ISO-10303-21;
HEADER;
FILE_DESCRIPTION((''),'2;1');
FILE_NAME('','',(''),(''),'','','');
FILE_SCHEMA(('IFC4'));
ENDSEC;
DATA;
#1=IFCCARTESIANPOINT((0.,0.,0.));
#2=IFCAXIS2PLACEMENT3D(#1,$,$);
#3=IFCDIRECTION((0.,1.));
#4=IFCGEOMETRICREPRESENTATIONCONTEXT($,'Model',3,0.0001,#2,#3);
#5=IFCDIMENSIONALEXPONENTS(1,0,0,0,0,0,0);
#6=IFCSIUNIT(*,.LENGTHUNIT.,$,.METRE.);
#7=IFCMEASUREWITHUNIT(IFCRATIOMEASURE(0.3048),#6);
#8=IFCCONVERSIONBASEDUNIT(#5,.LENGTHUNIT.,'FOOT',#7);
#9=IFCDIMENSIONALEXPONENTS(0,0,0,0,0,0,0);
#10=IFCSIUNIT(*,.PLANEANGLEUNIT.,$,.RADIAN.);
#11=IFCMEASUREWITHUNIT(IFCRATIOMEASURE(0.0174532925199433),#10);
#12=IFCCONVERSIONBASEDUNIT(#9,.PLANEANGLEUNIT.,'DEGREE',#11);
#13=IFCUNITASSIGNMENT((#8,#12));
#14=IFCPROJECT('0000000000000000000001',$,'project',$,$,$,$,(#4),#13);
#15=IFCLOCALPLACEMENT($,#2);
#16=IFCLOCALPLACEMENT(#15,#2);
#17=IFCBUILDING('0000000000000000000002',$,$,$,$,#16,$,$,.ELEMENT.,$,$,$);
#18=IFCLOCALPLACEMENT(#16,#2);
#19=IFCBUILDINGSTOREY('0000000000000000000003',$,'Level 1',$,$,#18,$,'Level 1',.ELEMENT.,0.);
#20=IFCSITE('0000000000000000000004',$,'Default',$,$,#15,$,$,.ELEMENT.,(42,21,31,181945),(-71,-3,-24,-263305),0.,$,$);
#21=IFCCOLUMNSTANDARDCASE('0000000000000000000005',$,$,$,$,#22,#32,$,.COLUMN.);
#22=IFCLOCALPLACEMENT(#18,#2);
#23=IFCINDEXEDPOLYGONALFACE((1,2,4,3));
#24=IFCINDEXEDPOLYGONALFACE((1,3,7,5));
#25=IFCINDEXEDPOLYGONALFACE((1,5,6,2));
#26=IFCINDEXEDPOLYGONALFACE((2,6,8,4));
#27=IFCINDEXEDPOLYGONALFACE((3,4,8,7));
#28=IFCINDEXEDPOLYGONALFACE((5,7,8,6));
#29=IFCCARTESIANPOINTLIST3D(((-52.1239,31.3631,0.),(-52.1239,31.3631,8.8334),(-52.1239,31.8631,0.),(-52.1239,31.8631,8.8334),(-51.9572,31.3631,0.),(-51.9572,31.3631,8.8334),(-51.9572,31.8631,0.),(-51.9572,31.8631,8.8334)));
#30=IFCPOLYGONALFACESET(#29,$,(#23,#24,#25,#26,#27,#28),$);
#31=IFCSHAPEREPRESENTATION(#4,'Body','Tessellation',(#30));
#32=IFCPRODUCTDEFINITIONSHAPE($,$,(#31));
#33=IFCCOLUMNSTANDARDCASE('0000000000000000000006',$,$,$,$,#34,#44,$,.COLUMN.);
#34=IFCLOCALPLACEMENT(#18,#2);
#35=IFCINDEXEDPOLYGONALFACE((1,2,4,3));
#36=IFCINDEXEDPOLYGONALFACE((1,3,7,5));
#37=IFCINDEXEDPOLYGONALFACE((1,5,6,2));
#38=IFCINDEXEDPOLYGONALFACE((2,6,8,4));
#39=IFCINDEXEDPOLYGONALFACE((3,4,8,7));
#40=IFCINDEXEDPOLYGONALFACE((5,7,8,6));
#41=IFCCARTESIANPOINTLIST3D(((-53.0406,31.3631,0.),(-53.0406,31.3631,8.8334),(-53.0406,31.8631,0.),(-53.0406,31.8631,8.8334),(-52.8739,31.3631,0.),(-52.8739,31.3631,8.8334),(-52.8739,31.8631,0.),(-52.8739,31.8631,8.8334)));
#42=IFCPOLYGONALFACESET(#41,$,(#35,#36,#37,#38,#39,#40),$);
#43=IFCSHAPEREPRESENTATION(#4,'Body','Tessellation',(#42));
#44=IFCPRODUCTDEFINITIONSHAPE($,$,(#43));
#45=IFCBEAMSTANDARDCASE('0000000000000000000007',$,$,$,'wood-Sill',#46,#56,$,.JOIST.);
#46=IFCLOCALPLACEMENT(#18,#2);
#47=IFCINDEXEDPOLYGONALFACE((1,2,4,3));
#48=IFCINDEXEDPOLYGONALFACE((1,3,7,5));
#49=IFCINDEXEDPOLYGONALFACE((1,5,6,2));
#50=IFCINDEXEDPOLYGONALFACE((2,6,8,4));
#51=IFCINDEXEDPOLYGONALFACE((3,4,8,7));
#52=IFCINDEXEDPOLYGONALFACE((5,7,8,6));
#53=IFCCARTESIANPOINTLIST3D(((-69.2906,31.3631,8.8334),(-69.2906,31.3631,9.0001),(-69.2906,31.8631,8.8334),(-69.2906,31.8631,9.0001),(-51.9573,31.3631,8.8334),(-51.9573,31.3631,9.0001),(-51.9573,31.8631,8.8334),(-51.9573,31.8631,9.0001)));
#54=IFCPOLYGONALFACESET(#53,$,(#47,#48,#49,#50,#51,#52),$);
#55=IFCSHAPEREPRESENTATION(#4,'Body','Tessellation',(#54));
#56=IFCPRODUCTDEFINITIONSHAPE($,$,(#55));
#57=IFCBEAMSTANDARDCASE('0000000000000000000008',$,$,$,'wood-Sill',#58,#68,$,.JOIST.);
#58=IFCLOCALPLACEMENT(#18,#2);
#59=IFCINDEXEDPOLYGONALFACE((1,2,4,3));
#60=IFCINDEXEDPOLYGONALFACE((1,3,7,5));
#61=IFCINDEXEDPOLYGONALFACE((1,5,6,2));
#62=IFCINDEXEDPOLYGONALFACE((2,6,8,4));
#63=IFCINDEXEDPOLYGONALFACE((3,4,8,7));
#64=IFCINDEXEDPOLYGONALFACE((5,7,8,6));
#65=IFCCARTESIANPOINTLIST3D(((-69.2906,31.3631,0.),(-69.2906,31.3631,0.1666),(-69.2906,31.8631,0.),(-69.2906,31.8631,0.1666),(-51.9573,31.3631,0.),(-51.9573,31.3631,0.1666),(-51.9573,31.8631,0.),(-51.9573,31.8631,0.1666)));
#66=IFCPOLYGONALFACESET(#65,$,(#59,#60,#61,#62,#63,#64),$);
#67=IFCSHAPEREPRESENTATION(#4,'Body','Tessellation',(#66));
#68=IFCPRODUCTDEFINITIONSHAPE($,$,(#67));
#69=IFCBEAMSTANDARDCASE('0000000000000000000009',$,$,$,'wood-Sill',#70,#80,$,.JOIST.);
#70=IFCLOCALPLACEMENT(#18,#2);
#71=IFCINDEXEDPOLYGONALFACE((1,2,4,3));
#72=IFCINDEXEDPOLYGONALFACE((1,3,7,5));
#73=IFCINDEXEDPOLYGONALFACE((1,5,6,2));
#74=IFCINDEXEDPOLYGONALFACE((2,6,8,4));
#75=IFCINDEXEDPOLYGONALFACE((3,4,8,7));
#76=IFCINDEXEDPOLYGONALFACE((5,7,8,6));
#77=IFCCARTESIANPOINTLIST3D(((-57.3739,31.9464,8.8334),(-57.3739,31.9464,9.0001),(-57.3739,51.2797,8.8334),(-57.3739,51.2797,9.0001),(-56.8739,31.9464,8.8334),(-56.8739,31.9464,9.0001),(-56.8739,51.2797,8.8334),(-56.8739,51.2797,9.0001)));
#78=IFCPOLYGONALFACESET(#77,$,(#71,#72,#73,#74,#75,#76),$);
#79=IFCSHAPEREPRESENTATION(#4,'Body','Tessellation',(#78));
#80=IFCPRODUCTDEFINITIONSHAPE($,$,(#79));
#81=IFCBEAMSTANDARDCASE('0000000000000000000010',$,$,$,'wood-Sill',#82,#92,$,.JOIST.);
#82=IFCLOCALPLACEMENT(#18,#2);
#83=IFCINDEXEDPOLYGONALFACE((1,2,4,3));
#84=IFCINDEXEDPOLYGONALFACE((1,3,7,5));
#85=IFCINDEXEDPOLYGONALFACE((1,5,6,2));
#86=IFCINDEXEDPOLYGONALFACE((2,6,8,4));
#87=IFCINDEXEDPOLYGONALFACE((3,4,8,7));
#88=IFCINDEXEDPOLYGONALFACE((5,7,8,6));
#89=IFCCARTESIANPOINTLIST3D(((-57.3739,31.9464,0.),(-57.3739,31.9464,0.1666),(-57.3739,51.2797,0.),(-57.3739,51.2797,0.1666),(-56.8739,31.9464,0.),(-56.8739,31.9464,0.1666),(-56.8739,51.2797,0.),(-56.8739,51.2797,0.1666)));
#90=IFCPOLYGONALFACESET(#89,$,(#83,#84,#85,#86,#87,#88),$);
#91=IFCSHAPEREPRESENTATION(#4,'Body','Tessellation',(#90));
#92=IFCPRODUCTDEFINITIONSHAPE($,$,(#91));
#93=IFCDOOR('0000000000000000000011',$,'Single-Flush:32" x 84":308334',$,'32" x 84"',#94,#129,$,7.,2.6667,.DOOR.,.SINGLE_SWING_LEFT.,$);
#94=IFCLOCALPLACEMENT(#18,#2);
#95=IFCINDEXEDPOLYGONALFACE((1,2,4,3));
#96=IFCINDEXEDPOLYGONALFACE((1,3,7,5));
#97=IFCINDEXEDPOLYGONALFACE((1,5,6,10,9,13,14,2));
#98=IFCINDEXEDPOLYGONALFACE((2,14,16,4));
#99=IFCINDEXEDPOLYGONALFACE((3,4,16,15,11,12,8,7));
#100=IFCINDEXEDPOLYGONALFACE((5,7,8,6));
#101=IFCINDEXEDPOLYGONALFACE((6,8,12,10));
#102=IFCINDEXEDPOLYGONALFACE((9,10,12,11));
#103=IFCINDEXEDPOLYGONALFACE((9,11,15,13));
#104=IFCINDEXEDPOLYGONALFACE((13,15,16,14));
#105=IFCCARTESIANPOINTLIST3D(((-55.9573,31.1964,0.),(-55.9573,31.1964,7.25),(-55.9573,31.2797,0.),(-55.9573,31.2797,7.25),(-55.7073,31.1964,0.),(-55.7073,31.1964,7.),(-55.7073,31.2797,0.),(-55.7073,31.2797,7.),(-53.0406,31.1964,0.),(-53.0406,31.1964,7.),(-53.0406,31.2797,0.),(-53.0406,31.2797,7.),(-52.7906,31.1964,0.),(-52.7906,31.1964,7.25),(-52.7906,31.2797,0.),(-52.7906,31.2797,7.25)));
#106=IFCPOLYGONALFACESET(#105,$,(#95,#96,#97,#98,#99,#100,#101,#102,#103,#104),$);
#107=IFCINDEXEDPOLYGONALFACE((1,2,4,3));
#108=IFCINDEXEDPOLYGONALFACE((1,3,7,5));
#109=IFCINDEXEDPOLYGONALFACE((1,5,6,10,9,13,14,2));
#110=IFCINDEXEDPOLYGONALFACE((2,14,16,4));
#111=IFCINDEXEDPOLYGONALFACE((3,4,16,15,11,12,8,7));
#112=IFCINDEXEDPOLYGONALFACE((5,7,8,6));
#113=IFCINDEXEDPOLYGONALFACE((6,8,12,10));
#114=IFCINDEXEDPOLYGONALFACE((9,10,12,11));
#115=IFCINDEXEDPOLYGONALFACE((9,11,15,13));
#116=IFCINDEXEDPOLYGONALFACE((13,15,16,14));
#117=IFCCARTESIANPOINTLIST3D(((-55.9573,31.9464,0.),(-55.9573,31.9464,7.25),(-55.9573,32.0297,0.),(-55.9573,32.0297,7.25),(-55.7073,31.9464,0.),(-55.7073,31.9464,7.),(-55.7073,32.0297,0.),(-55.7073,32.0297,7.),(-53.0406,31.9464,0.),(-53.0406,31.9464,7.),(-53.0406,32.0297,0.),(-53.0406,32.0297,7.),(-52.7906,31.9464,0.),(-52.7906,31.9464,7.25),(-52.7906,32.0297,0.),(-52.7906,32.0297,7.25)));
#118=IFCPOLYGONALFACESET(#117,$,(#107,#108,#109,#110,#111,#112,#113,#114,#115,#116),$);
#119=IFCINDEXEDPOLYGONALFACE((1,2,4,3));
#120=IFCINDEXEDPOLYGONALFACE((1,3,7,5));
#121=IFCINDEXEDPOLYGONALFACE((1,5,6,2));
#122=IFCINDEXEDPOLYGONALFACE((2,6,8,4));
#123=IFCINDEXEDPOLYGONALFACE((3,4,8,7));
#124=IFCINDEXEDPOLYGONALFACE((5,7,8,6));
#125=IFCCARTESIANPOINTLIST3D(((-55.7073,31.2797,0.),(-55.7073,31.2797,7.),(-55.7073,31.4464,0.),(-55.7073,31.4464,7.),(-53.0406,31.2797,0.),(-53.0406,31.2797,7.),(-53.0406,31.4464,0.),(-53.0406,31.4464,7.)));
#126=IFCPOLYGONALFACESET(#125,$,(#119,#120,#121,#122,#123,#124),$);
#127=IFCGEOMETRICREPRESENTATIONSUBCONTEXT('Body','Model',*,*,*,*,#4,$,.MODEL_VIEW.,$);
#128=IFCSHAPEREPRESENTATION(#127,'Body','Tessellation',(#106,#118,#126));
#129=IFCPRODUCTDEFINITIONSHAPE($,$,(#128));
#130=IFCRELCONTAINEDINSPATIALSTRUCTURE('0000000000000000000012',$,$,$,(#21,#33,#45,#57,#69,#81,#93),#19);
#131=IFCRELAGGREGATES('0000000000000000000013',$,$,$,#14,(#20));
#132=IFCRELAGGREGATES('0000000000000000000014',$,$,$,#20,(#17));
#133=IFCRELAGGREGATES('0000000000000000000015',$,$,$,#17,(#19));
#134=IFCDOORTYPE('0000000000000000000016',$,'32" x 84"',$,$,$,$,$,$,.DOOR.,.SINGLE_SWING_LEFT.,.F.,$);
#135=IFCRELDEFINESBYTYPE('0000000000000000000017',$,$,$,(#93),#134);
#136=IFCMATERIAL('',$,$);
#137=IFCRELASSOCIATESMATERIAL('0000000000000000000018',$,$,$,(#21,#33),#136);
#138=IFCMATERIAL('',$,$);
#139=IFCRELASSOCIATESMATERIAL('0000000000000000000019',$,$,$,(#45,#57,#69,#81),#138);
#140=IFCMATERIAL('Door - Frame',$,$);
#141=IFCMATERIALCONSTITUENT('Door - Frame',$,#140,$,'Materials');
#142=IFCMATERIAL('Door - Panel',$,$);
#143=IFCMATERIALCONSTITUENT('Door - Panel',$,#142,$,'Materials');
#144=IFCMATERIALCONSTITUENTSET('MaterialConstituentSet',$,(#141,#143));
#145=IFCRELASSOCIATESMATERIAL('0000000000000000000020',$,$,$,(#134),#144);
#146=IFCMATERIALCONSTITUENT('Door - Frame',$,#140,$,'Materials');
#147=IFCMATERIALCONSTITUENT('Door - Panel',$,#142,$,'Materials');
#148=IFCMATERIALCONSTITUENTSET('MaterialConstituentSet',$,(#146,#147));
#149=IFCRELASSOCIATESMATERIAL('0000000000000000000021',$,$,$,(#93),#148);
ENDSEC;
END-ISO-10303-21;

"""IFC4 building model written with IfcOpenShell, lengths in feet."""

from ifc_helpers import new_model, entity, si_unit, converted_unit, direction, frame, frame_2d, origin, origin_with_axes, place, context, subcontext, project, spatial, polyline, rectangle, outline, extrude, source, transform, mapped, material, constituent, constituent_set, type_object, type_shapes, element, save


model = new_model("IFC4")

# Units and contexts
model_context = context("Model", 3, precision=0.0001, world=origin(), true_north=direction((0.0, 1.0)))
body_context = subcontext(model_context, "Body", "Model", "MODEL_VIEW")
ifc_project = project(units=[converted_unit("LENGTHUNIT", "FOOT", entity("IfcRatioMeasure", 0.3048), si_unit("LENGTHUNIT", "METRE"), dimensions=[1, 0, 0, 0, 0, 0, 0]), converted_unit("PLANEANGLEUNIT", "DEGREE", entity("IfcRatioMeasure", 0.0174532925199433), si_unit("PLANEANGLEUNIT", "RADIAN"), dimensions=[0, 0, 0, 0, 0, 0, 0])], contexts=[model_context])

# Site, building, storey
site_placement = place(None, origin())
site = spatial("IfcSite", under=ifc_project, at=site_placement, Name="Default", CompositionType="ELEMENT", RefLatitude=(42, 21, 31, 181945), RefLongitude=(-71, -3, -24, -263305), RefElevation=0.0)
building_placement = place(site_placement, origin())
building = spatial("IfcBuilding", under=site, at=building_placement, CompositionType="ELEMENT")
storey_placement = place(building_placement, origin())
storey = spatial("IfcBuildingStorey", under=building, at=storey_placement, Name="Level 1", LongName="Level 1", CompositionType="ELEMENT", Elevation=0.0)

# Columns
ifc_material_1 = material(Name="")
placement_1 = place(storey_placement, frame((-51.9573, 31.6131, 0.0), z_axis=(0.0, 0.0, 1.0), x_axis=(-1.0, 0.0, 0.0)))
for number, where, z_axis, x_axis in (
    (1, (0.0833, 0.0, 0.0), (0.0, 0.0, 1.0), (1.0, 0.0, 0.0)),
    (2, (1.0, 0.0, 0.0), (0.0, 0.0, 1.0), (1.0, 0.0, 0.0)),
):
    element("IfcColumnStandardCase", number, at=place(placement_1, frame(where, z_axis=z_axis, x_axis=x_axis)), inside=storey, material=ifc_material_1, PredefinedType="COLUMN", context=model_context, shape_type="SweptSolid", body=[
        extrude(rectangle(XDim=0.1667, YDim=0.5), origin(), (0.0, 0.0, 1.0), 8.8334),
    ])

# Beams
ifc_material_2 = material(Name="")
for number, where, z_axis, x_axis in (
    (3, (0.0, 0.0, 8.9167), (1.0, 0.0, 0.0), (0.0, 0.0, 1.0)),
    (4, (0.0, 0.0, 0.0833), (1.0, 0.0, 0.0), (0.0, 0.0, 1.0)),
):
    element("IfcBeamStandardCase", number, at=place(placement_1, frame(where, z_axis=z_axis, x_axis=x_axis)), inside=storey, material=ifc_material_2, ObjectType="wood-Sill", PredefinedType="JOIST", context=model_context, shape_type="SweptSolid", body=[
        extrude(rectangle(XDim=0.1667, YDim=0.5), origin_with_axes(), (0.0, 0.0, 1.0), 17.3333),
    ])
placement_2 = place(storey_placement, frame((-57.1239, 31.9464, 0.0), z_axis=(0.0, 0.0, 1.0), x_axis=(0.0, 1.0, 0.0)))
for number, where, z_axis, x_axis in (
    (5, (0.0, 0.0, 8.9167), (1.0, 0.0, 0.0), (0.0, 0.0, 1.0)),
    (6, (0.0, 0.0, 0.0833), (1.0, 0.0, 0.0), (0.0, 0.0, 1.0)),
):
    element("IfcBeamStandardCase", number, at=place(placement_2, frame(where, z_axis=z_axis, x_axis=x_axis)), inside=storey, material=ifc_material_2, ObjectType="wood-Sill", PredefinedType="JOIST", context=model_context, shape_type="SweptSolid", body=[
        extrude(rectangle(XDim=0.1667, YDim=0.5), origin_with_axes(), (0.0, 0.0, 1.0), 19.3333),
    ])

# Door
ifc_material_3 = material(Name="Door - Frame")
ifc_constituent_1 = constituent(ifc_material_3, Name="Door - Frame", Category="Materials")
ifc_material_4 = material(Name="Door - Panel")
ifc_constituent_2 = constituent(ifc_material_4, Name="Door - Panel", Category="Materials")
ifc_constituent_set_1 = constituent_set(constituents=[ifc_constituent_1, ifc_constituent_2], Name="MaterialConstituentSet")
ifc_constituent_3 = constituent(ifc_material_3, Name="Door - Frame", Category="Materials")
ifc_constituent_4 = constituent(ifc_material_4, Name="Door - Panel", Category="Materials")
ifc_constituent_set_2 = constituent_set(constituents=[ifc_constituent_3, ifc_constituent_4], Name="MaterialConstituentSet")
door_type = type_object("IfcDoorType", Name="32\" x 84\"", OperationType="SINGLE_SWING_LEFT", ParameterTakesPrecedence=False, PredefinedType="DOOR", material=ifc_constituent_set_2)
shared_shape = source(origin(), body_context, "Body", "SweptSolid", [
    extrude(outline(polyline([(-1.5833, -3.6875), (1.5833, -3.6875), (1.5833, 3.5625), (1.3333, 3.5625), (1.3333, -3.4375), (-1.3333, -3.4375), (-1.3333, 3.5625), (-1.5833, 3.5625), (-1.5833, -3.6875)])), frame((1.3333, 0.75, 3.5625), z_axis=(0.0, -1.0, 0.0), x_axis=(-1.0, 0.0, 0.0)), (0.0, 0.0, 1.0), 0.0833),
    extrude(outline(polyline([(-3.6875, -1.5833), (3.5625, -1.5833), (3.5625, -1.3333), (-3.4375, -1.3333), (-3.4375, 1.3333), (3.5625, 1.3333), (3.5625, 1.5833), (-3.6875, 1.5833), (-3.6875, -1.5833)])), frame((1.3333, 0.0, 3.5625), z_axis=(0.0, -1.0, 0.0), x_axis=(0.0, 0.0, -1.0)), (0.0, 0.0, 1.0), 0.0833),
    extrude(rectangle(XDim=2.6667, YDim=0.1667, at=frame_2d((0.0, 0.0), x_axis=(1.0, 0.0))), frame((1.3333, 0.5833, 0.0)), (0.0, 0.0, 1.0), 7.0),
])
type_shapes(door_type, [shared_shape])
placement_3 = place(placement_1, frame((1.0833, -0.3333, 0.0)))
door_placement = place(placement_3, origin())
element("IfcDoor", 7, at=door_placement, inside=storey, type_object=door_type, material=ifc_constituent_set_1, Name="Single-Flush:32\" x 84\":308334", ObjectType="32\" x 84\"", OperationType="SINGLE_SWING_LEFT", OverallHeight=7.0, OverallWidth=2.6667, PredefinedType="DOOR", context=body_context, shape_type="MappedRepresentation", body=[
    mapped(shared_shape, transform((0.0, 0.0, 0.0), scale=1.0)),
])

save(model, "model.ifc")
